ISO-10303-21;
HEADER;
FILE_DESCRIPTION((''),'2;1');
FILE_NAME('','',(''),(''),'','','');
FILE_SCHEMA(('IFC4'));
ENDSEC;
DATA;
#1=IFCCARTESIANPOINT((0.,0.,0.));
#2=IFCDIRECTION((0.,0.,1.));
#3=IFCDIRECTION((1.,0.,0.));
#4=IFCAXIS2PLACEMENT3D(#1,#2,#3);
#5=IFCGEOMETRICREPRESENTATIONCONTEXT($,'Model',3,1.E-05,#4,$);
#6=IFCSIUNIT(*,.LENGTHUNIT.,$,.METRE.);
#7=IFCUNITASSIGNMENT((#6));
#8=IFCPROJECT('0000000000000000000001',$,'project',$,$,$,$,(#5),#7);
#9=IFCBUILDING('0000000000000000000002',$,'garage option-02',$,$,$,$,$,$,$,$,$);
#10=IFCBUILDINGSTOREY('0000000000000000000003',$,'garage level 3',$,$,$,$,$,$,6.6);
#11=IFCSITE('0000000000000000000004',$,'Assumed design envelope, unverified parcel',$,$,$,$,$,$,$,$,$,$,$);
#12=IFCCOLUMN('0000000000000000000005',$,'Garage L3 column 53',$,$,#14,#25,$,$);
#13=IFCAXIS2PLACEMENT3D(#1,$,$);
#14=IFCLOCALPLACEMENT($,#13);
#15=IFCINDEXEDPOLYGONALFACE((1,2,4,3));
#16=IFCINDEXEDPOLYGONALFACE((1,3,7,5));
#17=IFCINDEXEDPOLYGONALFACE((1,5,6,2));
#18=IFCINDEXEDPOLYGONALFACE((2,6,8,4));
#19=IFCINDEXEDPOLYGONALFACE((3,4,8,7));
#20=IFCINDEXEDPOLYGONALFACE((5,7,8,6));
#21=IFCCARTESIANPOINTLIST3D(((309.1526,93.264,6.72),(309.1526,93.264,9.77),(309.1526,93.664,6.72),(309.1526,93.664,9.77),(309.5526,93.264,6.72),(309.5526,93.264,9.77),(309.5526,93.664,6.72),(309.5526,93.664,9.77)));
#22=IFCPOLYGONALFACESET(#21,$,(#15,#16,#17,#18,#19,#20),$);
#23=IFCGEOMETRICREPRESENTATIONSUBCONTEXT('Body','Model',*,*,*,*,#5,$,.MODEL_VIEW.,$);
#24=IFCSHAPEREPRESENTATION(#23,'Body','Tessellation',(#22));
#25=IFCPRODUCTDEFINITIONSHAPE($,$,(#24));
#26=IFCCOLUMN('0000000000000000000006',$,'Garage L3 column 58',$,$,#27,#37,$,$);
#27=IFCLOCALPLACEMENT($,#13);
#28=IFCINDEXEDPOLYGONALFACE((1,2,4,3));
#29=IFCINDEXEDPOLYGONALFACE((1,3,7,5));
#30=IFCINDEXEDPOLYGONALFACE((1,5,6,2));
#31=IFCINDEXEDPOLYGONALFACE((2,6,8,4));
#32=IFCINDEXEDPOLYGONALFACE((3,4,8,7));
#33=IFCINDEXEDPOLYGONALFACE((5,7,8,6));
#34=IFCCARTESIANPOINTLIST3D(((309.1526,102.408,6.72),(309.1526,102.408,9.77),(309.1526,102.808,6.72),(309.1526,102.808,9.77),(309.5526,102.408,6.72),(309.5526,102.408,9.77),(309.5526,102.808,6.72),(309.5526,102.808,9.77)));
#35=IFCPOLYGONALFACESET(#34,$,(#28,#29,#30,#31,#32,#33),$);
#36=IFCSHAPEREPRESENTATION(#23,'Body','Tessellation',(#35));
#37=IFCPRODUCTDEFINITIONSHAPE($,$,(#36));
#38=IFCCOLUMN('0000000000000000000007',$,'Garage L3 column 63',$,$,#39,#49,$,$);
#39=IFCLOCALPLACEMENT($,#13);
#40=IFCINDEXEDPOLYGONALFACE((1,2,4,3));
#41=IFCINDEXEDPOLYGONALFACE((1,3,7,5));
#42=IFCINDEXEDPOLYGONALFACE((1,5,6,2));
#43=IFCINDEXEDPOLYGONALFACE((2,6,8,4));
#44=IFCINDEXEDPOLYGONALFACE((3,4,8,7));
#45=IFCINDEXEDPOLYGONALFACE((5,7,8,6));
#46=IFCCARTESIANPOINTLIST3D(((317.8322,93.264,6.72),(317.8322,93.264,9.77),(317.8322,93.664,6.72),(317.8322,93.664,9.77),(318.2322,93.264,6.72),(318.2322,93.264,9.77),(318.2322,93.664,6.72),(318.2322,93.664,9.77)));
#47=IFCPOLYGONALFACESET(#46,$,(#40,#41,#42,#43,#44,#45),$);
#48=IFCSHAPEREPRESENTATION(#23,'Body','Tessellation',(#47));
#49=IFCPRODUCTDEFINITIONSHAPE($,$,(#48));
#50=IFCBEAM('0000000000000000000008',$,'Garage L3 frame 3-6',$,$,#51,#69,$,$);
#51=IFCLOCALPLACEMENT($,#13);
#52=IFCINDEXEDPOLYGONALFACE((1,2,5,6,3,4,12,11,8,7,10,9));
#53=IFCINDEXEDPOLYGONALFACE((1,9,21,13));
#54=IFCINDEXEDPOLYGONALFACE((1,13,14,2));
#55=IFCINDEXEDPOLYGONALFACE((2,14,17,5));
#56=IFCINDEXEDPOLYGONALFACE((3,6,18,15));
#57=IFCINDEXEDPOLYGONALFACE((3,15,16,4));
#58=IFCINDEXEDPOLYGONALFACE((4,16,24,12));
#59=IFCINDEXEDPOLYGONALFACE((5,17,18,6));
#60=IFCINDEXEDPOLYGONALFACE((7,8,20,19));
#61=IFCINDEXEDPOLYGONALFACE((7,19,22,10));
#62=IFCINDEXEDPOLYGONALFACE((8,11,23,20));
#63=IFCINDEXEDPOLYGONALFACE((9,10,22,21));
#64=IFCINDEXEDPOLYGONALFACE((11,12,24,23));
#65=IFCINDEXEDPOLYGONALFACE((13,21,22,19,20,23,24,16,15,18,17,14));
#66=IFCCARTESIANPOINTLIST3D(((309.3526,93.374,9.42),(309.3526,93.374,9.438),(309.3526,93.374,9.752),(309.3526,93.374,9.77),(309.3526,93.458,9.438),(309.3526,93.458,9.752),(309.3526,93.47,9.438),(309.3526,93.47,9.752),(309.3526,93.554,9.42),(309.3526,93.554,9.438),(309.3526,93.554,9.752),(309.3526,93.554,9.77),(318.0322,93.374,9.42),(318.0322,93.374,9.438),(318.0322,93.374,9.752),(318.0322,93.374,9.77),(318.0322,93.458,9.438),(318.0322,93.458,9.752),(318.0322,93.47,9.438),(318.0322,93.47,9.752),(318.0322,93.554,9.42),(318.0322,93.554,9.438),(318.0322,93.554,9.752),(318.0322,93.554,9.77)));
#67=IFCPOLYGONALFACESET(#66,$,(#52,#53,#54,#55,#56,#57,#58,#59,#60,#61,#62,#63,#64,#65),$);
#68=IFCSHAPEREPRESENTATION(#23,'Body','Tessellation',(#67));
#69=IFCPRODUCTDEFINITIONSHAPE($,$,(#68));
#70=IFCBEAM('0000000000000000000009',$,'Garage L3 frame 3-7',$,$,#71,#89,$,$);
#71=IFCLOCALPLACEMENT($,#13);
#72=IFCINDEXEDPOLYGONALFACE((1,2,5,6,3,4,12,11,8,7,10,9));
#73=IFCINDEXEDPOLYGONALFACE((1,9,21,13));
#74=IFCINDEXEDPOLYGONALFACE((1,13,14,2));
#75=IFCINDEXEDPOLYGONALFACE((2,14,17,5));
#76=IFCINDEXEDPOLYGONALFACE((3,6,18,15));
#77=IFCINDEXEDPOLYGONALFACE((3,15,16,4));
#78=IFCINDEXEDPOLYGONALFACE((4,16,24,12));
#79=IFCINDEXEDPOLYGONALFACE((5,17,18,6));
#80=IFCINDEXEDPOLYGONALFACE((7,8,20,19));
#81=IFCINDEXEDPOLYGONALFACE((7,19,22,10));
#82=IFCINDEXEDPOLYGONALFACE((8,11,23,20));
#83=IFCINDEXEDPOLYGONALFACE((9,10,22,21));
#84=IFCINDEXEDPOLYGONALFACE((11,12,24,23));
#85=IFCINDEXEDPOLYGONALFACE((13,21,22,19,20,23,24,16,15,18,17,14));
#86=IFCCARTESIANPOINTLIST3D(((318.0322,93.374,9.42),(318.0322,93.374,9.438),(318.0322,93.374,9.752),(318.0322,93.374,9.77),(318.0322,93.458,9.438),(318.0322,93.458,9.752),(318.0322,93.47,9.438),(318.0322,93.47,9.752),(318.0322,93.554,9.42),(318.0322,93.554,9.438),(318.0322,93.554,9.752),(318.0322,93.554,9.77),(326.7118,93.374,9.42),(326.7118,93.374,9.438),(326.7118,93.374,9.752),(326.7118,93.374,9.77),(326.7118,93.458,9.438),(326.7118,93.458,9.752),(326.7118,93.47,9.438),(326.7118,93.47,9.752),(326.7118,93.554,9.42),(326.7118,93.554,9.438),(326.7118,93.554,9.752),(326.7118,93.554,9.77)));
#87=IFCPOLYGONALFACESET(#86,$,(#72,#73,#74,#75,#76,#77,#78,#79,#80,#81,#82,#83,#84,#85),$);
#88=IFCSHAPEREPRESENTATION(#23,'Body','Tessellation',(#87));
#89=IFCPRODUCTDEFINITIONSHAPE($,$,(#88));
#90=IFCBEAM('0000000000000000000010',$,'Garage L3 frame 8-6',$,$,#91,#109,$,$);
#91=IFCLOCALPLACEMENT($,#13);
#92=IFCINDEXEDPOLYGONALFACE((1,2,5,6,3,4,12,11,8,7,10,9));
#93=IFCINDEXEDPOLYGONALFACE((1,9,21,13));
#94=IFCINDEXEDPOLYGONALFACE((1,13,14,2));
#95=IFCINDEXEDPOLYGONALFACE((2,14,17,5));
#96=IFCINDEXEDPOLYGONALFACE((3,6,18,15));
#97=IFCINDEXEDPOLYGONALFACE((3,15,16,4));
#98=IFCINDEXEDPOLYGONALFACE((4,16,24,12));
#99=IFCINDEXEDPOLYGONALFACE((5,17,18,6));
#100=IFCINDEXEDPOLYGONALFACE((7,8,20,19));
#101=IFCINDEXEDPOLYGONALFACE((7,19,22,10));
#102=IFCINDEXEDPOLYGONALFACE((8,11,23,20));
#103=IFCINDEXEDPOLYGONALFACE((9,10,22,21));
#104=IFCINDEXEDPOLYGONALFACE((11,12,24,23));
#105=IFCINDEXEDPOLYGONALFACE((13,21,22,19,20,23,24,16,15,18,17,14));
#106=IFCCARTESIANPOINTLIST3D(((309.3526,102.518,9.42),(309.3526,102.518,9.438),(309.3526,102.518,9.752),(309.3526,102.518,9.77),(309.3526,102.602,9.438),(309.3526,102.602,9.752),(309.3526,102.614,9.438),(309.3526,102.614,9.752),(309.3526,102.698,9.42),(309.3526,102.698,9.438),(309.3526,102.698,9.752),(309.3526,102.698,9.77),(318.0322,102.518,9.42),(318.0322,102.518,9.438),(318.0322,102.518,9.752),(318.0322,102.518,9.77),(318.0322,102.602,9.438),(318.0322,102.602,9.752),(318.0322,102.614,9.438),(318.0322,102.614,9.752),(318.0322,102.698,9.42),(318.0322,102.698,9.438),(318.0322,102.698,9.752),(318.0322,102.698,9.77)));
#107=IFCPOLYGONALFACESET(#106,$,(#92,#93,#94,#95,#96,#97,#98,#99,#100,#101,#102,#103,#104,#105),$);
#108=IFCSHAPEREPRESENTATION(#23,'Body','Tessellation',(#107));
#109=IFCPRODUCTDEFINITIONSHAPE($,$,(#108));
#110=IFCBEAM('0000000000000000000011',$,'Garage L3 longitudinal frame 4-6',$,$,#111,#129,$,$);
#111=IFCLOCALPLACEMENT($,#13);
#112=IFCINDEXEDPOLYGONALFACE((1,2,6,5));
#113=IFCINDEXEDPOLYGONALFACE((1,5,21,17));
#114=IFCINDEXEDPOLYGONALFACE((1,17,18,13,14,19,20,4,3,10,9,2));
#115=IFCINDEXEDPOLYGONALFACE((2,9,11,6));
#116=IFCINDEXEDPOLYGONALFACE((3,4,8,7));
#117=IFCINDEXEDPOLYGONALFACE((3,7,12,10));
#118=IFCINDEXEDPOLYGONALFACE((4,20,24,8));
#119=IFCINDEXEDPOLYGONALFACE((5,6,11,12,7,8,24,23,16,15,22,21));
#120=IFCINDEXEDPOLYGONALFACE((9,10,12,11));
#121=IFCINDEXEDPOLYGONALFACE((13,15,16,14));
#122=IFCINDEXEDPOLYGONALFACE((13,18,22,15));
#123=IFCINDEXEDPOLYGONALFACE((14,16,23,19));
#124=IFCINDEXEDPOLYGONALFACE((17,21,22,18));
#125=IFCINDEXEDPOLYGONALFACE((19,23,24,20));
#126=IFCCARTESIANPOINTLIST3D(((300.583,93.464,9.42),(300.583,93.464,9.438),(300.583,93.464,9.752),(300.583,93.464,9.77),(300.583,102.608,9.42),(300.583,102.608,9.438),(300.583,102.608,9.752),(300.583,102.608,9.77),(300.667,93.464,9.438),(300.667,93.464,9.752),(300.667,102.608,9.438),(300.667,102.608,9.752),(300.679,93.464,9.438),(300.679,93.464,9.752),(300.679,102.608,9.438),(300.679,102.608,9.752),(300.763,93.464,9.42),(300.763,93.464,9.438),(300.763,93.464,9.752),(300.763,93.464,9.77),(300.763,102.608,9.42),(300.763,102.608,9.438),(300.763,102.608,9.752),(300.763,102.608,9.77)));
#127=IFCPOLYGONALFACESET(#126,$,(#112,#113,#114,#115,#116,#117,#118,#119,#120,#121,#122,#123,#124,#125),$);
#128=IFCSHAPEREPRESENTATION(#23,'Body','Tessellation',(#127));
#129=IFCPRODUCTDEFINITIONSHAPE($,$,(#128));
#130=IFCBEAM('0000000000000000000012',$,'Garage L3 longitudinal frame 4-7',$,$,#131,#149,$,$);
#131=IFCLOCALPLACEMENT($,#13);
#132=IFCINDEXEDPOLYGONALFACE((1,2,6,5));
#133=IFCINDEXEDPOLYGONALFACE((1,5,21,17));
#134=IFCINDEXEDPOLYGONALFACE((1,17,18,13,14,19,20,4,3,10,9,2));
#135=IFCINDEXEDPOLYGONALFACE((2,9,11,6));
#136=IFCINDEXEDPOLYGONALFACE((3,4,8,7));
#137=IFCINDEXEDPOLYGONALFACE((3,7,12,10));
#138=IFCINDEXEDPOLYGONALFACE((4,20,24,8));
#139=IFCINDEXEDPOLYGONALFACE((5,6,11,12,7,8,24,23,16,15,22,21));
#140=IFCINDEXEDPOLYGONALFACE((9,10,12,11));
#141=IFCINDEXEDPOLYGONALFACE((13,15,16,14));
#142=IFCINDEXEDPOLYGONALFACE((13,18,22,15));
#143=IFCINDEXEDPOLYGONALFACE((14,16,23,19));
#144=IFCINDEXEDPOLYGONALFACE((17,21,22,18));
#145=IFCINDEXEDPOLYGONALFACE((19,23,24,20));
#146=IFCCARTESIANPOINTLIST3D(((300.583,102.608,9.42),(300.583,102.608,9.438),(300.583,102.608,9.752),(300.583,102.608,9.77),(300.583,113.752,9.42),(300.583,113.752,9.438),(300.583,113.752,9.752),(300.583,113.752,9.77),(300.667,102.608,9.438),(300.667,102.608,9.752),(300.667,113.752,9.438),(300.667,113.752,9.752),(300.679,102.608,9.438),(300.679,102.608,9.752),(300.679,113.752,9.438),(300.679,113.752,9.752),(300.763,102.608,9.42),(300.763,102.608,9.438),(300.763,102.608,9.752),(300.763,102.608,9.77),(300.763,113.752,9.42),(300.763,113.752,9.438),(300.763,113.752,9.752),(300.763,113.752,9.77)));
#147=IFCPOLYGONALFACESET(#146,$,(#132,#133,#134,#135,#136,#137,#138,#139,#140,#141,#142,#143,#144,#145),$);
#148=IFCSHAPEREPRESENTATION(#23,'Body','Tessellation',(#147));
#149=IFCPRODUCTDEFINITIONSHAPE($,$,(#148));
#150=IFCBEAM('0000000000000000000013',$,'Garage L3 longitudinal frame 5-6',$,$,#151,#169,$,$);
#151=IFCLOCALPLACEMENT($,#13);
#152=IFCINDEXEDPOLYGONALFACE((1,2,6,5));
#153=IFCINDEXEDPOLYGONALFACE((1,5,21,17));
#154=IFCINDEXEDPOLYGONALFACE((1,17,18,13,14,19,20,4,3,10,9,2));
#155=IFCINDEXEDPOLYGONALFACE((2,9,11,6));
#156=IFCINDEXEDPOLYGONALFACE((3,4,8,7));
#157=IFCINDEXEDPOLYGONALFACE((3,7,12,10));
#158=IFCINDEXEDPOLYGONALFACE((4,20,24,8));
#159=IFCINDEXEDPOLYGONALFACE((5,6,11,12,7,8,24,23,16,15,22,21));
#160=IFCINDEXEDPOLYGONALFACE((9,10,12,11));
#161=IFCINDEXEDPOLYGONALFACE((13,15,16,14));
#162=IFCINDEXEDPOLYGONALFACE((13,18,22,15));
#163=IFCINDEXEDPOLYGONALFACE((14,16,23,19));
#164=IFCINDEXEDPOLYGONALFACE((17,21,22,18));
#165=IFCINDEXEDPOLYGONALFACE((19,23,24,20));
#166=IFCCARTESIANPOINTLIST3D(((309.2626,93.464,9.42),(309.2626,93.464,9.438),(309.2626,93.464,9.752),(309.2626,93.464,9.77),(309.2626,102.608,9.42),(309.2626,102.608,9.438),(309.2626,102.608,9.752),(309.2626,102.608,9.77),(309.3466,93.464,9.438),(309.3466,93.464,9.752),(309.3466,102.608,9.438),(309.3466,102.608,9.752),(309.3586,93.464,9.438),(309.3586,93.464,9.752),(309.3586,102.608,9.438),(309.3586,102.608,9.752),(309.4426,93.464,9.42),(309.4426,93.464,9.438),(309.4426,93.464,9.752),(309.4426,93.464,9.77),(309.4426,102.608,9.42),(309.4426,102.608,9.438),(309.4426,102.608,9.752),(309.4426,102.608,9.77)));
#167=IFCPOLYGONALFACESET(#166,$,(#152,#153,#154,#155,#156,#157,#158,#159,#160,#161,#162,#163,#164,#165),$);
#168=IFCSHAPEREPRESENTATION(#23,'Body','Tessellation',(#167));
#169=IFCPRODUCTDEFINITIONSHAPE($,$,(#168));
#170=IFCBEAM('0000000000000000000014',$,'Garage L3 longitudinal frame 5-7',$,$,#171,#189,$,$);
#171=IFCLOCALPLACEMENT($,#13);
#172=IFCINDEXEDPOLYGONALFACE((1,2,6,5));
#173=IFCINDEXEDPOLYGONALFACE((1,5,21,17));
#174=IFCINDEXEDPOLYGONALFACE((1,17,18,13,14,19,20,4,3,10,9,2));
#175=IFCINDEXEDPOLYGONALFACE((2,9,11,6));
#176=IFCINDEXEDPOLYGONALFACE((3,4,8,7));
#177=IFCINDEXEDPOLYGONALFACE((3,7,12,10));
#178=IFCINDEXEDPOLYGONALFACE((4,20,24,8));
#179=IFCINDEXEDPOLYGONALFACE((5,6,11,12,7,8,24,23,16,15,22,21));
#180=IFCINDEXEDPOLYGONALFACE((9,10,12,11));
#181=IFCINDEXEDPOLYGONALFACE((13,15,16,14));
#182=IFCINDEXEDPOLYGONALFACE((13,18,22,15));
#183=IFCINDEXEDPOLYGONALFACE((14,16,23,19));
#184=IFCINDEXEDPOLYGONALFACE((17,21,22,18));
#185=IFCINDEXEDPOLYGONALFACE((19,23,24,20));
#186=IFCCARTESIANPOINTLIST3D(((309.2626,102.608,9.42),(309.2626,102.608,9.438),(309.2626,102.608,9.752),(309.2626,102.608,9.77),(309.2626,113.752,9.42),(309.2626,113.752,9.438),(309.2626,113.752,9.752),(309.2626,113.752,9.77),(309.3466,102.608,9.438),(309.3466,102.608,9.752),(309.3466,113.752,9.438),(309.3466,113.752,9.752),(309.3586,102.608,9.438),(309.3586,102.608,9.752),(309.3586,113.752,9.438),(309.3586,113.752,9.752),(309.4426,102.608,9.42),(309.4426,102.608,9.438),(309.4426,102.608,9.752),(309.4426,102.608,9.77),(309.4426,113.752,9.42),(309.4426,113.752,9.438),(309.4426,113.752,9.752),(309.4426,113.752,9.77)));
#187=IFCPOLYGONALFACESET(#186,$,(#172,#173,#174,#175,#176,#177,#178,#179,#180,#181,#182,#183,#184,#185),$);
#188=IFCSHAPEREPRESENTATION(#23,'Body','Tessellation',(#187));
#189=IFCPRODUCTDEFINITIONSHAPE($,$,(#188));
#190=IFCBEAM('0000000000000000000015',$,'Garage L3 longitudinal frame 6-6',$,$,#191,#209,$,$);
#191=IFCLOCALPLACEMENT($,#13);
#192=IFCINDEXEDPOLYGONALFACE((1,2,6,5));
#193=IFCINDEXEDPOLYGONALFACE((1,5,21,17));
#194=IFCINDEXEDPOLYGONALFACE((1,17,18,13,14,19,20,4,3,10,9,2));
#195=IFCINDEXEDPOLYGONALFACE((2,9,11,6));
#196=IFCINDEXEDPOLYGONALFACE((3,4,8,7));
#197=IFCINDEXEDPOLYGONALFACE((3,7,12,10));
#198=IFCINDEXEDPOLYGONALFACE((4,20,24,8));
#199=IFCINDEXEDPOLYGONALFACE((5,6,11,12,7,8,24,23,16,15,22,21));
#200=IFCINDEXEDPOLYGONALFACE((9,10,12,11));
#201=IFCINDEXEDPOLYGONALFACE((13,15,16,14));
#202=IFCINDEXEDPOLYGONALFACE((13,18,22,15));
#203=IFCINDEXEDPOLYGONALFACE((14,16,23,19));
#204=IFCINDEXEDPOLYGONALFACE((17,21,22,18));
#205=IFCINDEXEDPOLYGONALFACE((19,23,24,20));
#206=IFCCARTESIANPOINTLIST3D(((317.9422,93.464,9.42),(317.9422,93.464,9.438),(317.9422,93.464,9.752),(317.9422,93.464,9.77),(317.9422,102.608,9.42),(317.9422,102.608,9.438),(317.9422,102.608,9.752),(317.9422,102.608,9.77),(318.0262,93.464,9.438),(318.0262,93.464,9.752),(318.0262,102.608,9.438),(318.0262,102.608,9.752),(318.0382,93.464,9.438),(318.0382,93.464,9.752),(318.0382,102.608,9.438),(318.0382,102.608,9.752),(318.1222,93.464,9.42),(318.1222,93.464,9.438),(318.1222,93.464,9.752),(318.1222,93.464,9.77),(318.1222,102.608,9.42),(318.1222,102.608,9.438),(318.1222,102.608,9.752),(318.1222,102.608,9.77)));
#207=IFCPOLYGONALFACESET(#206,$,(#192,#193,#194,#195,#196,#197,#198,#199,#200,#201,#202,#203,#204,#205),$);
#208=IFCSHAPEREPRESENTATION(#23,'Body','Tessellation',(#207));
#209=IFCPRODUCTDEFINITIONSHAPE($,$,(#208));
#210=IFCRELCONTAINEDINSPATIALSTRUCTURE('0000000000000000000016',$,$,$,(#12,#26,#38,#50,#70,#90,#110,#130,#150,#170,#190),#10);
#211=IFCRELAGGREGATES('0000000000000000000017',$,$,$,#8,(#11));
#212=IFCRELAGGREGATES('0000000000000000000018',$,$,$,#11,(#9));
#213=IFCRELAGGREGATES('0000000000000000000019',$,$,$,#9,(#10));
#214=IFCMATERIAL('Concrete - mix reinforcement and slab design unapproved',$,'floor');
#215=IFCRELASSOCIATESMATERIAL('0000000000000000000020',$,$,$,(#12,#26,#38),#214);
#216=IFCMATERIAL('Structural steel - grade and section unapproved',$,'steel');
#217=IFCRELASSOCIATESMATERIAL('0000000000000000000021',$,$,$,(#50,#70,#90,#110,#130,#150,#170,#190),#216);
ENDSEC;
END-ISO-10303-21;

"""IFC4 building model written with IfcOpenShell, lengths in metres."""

from ifc_helpers import new_model, si_unit, frame, origin_with_axes, place, context, subcontext, project, spatial, rectangle, i_section, extrude, material, element, save


model = new_model("IFC4")

# Units and contexts
model_context = context("Model", 3, precision=1e-05, world=origin_with_axes())
body_context = subcontext(model_context, "Body", "Model", "MODEL_VIEW")
ifc_project = project(units=[si_unit("LENGTHUNIT", "METRE")], contexts=[model_context])

# Site, building, storey
site = spatial("IfcSite", under=ifc_project, Name="Assumed design envelope, unverified parcel")
building = spatial("IfcBuilding", under=site, Name="garage option-02")
storey = spatial("IfcBuildingStorey", under=building, Name="garage level 3", Elevation=6.6)

# Columns
ifc_material_1 = material(Name="Concrete - mix reinforcement and slab design unapproved", Category="floor")
for number, where, z_axis, x_axis, name in (
    (1, (309.3526, 93.464, 6.72), (0.0, 0.0, 1.0), (1.0, 0.0, 0.0), "Garage L3 column 53"),
    (2, (309.3526, 102.608, 6.72), (0.0, 0.0, 1.0), (1.0, 0.0, 0.0), "Garage L3 column 58"),
    (3, (318.0322, 93.464, 6.72), (0.0, 0.0, 1.0), (1.0, 0.0, 0.0), "Garage L3 column 63"),
):
    element("IfcColumn", number, at=place(None, frame(where, z_axis=z_axis, x_axis=x_axis)), inside=storey, material=ifc_material_1, Name=name, context=body_context, shape_type="SweptSolid", body=[
        extrude(rectangle(XDim=0.4, YDim=0.4), origin_with_axes(), (0.0, 0.0, 1.0), 3.05),
    ])

# Beams
ifc_material_2 = material(Name="Structural steel - grade and section unapproved", Category="steel")
for number, where, z_axis, x_axis, name in (
    (4, (309.3526, 93.464, 9.595), (1.0, 0.0, 0.0), (0.0, 1.0, 0.0), "Garage L3 frame 3-6"),
    (5, (318.0322, 93.464, 9.595), (1.0, 0.0, 0.0), (0.0, 1.0, 0.0), "Garage L3 frame 3-7"),
    (6, (309.3526, 102.608, 9.595), (1.0, 0.0, 0.0), (0.0, 1.0, 0.0), "Garage L3 frame 8-6"),
):
    element("IfcBeam", number, at=place(None, frame(where, z_axis=z_axis, x_axis=x_axis)), inside=storey, material=ifc_material_2, Name=name, context=body_context, shape_type="SweptSolid", body=[
        extrude(i_section(OverallWidth=0.18, OverallDepth=0.35, WebThickness=0.012, FlangeThickness=0.018, FilletRadius=0.0), origin_with_axes(), (0.0, 0.0, 1.0), 8.6796),
    ])
beam_1_placement = place(None, frame((300.673, 93.464, 9.595), z_axis=(0.0, 1.0, 0.0), x_axis=(-1.0, 0.0, 0.0)))
element("IfcBeam", 7, at=beam_1_placement, inside=storey, material=ifc_material_2, Name="Garage L3 longitudinal frame 4-6", context=body_context, shape_type="SweptSolid", body=[
    extrude(i_section(OverallWidth=0.18, OverallDepth=0.35, WebThickness=0.012, FlangeThickness=0.018, FilletRadius=0.0), origin_with_axes(), (0.0, 0.0, 1.0), 9.144),
])
beam_2_placement = place(None, frame((300.673, 102.608, 9.595), z_axis=(0.0, 1.0, 0.0), x_axis=(-1.0, 0.0, 0.0)))
element("IfcBeam", 8, at=beam_2_placement, inside=storey, material=ifc_material_2, Name="Garage L3 longitudinal frame 4-7", context=body_context, shape_type="SweptSolid", body=[
    extrude(i_section(OverallWidth=0.18, OverallDepth=0.35, WebThickness=0.012, FlangeThickness=0.018, FilletRadius=0.0), origin_with_axes(), (0.0, 0.0, 1.0), 11.144),
])
beam_3_placement = place(None, frame((309.3526, 93.464, 9.595), z_axis=(0.0, 1.0, 0.0), x_axis=(-1.0, 0.0, 0.0)))
element("IfcBeam", 9, at=beam_3_placement, inside=storey, material=ifc_material_2, Name="Garage L3 longitudinal frame 5-6", context=body_context, shape_type="SweptSolid", body=[
    extrude(i_section(OverallWidth=0.18, OverallDepth=0.35, WebThickness=0.012, FlangeThickness=0.018, FilletRadius=0.0), origin_with_axes(), (0.0, 0.0, 1.0), 9.144),
])
beam_4_placement = place(None, frame((309.3526, 102.608, 9.595), z_axis=(0.0, 1.0, 0.0), x_axis=(-1.0, 0.0, 0.0)))
element("IfcBeam", 10, at=beam_4_placement, inside=storey, material=ifc_material_2, Name="Garage L3 longitudinal frame 5-7", context=body_context, shape_type="SweptSolid", body=[
    extrude(i_section(OverallWidth=0.18, OverallDepth=0.35, WebThickness=0.012, FlangeThickness=0.018, FilletRadius=0.0), origin_with_axes(), (0.0, 0.0, 1.0), 11.144),
])
beam_5_placement = place(None, frame((318.0322, 93.464, 9.595), z_axis=(0.0, 1.0, 0.0), x_axis=(-1.0, 0.0, 0.0)))
element("IfcBeam", 11, at=beam_5_placement, inside=storey, material=ifc_material_2, Name="Garage L3 longitudinal frame 6-6", context=body_context, shape_type="SweptSolid", body=[
    extrude(i_section(OverallWidth=0.18, OverallDepth=0.35, WebThickness=0.012, FlangeThickness=0.018, FilletRadius=0.0), origin_with_axes(), (0.0, 0.0, 1.0), 9.144),
])

save(model, "model.ifc")
